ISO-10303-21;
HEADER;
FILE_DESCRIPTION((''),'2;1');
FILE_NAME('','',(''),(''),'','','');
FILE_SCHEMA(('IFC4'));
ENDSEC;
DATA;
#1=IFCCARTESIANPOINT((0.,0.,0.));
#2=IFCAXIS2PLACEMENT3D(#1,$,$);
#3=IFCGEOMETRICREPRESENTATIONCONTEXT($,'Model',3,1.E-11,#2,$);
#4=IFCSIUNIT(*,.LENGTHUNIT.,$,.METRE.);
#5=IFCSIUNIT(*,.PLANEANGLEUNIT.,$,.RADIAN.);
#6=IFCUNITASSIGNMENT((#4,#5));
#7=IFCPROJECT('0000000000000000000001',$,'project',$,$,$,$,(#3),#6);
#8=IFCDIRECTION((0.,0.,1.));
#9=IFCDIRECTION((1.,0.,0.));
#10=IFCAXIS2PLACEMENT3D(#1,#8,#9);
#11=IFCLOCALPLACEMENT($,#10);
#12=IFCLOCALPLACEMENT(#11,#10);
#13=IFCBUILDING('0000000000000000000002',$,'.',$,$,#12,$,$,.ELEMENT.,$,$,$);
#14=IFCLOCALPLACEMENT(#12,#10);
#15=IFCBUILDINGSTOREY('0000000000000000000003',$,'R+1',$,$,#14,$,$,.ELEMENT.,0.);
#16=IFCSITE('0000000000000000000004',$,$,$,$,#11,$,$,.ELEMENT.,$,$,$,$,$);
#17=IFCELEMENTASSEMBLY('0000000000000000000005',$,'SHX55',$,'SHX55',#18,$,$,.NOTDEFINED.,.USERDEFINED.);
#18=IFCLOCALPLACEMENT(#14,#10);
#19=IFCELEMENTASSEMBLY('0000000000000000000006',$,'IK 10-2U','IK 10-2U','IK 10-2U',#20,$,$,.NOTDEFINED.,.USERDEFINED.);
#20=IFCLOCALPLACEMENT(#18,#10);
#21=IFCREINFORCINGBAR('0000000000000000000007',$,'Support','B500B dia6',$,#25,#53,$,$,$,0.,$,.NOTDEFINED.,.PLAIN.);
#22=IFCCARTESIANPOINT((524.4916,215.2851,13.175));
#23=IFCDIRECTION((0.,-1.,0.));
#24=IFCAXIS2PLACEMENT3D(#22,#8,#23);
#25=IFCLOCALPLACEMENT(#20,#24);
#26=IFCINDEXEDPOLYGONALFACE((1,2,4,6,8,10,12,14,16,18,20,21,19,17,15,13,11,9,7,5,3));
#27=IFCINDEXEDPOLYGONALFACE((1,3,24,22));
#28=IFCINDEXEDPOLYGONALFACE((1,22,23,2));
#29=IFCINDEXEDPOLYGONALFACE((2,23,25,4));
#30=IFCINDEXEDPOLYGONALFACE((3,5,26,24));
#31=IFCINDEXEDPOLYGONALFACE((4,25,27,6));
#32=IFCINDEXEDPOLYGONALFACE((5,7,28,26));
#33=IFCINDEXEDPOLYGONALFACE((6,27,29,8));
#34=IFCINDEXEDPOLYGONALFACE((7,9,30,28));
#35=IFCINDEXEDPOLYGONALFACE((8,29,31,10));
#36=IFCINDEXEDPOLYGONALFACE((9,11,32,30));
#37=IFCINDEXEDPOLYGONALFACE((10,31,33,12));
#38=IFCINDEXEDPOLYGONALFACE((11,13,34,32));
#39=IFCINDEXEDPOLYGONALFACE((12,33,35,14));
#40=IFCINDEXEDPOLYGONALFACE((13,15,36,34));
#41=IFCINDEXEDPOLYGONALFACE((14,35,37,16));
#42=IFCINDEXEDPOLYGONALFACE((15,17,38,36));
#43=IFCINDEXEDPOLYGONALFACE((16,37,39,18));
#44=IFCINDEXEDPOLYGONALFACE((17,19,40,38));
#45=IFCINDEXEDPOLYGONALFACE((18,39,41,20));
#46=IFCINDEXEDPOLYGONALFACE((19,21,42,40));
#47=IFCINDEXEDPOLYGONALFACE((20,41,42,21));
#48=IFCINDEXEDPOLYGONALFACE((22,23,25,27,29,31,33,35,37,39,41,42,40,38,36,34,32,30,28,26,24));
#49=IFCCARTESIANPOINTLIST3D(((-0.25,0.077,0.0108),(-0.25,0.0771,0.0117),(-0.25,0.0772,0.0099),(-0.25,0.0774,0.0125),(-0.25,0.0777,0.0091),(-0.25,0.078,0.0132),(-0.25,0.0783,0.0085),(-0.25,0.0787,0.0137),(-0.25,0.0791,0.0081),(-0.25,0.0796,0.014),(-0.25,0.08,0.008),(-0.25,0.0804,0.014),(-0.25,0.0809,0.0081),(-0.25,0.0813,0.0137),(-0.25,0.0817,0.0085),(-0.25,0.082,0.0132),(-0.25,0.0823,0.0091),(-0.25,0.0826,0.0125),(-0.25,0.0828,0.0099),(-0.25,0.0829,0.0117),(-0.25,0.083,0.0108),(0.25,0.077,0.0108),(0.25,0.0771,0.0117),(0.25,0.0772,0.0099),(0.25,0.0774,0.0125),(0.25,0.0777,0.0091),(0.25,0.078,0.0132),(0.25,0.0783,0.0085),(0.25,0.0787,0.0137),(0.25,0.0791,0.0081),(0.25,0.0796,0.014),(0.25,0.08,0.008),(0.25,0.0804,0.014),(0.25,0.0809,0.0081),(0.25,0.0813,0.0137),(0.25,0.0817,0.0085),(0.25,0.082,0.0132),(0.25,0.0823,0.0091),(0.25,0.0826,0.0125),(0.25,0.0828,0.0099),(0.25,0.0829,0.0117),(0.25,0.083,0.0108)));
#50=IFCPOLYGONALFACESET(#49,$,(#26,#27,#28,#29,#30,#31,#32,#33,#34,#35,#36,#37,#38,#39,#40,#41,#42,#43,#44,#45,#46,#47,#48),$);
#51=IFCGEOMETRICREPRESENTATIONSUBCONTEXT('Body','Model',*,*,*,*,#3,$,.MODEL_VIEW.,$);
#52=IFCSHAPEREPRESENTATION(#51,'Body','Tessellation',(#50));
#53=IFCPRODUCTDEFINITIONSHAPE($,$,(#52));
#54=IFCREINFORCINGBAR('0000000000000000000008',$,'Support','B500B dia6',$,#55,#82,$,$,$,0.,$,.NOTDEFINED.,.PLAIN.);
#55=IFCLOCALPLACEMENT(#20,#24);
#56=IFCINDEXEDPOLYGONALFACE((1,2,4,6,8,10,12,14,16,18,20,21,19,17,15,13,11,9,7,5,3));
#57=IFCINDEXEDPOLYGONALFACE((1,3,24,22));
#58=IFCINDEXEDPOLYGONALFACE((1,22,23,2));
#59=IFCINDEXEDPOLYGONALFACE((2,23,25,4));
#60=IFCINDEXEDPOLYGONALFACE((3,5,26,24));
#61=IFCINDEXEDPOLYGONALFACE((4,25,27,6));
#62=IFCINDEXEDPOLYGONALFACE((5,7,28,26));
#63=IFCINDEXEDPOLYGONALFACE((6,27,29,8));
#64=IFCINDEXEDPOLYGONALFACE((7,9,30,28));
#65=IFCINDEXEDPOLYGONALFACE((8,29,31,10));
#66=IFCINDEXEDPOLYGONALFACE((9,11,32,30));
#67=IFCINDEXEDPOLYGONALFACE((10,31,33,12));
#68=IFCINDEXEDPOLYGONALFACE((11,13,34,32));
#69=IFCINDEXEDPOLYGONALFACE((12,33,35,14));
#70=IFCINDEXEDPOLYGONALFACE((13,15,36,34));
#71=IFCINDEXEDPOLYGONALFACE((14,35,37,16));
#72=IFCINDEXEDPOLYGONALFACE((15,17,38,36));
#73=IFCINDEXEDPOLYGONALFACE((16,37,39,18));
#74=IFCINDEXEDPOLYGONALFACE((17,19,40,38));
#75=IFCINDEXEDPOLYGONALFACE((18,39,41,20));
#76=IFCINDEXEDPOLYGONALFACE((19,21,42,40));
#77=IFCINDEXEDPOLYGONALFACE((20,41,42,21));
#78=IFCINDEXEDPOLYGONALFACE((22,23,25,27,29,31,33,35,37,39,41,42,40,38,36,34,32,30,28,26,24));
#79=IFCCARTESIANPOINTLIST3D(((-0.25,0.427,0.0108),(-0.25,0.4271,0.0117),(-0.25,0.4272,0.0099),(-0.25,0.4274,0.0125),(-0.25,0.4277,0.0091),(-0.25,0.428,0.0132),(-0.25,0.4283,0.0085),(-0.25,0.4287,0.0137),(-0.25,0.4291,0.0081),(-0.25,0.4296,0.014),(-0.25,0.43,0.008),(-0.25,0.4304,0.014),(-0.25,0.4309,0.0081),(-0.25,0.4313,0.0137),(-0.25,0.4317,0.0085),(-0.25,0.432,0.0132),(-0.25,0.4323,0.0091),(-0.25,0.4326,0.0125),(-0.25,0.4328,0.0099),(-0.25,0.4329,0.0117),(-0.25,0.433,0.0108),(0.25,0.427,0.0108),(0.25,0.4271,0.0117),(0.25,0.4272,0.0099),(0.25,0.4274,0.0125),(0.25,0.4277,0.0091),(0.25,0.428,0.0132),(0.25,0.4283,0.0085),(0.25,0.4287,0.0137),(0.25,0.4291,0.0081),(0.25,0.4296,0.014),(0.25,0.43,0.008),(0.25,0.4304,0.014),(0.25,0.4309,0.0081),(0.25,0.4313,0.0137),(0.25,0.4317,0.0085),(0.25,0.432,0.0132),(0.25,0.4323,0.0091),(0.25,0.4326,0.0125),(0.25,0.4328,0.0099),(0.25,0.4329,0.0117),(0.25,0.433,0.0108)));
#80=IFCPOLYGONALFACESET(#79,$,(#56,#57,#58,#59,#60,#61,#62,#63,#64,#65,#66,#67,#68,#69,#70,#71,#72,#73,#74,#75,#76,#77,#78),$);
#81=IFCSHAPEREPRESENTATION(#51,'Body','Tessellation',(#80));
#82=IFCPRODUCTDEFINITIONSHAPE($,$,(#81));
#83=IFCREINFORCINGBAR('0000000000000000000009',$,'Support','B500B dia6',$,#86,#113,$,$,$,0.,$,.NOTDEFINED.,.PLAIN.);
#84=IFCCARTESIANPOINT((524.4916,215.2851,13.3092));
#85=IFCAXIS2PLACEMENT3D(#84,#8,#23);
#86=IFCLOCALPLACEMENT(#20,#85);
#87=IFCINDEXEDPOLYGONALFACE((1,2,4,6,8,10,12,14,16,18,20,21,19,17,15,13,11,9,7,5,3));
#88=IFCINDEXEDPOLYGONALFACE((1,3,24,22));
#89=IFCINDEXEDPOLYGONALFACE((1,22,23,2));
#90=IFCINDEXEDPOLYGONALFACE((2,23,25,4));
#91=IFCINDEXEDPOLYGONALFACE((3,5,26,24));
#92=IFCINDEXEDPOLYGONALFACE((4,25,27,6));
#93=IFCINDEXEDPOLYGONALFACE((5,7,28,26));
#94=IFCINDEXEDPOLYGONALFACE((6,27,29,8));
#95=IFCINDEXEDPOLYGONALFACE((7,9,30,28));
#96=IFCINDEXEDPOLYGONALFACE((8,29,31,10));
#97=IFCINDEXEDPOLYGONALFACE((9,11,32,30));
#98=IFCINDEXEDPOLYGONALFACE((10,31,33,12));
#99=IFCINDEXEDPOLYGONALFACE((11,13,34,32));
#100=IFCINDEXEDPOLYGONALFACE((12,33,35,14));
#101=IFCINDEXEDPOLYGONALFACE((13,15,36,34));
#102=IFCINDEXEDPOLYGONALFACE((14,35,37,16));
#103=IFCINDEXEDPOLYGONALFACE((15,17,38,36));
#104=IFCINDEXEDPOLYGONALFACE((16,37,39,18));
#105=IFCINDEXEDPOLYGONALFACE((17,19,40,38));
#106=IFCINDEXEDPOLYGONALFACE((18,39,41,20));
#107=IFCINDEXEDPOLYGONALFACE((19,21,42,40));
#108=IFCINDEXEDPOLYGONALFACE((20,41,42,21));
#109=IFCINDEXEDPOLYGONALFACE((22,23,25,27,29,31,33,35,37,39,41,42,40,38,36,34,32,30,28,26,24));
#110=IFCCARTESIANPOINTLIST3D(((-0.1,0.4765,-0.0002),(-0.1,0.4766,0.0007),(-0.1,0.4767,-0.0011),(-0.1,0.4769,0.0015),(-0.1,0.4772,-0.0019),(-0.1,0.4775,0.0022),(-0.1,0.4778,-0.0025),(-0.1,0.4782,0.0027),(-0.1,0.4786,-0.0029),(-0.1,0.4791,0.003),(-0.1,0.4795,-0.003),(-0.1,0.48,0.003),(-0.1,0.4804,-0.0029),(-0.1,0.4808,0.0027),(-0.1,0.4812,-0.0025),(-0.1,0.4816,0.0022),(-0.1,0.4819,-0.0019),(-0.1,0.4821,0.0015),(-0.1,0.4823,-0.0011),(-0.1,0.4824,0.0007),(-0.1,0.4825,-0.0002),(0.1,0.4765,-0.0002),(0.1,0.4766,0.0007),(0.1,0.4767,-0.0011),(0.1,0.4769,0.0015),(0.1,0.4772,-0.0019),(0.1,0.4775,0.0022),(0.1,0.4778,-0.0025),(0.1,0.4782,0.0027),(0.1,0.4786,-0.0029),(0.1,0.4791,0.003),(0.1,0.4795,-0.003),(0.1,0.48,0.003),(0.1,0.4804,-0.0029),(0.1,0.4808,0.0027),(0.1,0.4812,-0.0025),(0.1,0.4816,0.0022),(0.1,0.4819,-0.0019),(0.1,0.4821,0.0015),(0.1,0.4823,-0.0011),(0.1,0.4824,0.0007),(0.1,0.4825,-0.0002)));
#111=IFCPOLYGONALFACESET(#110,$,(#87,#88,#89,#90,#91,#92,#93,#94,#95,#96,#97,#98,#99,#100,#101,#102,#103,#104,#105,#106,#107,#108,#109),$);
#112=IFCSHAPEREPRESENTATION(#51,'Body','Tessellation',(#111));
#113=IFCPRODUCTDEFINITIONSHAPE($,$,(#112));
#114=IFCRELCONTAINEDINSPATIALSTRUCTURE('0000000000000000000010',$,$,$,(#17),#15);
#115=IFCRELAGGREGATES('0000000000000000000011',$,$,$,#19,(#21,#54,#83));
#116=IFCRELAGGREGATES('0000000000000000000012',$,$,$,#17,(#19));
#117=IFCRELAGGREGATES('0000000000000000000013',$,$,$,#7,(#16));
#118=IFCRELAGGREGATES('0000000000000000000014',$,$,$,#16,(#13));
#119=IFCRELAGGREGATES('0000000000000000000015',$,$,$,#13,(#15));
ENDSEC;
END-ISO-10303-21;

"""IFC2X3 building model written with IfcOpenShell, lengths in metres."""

from ifc_helpers import new_model, entity, si_unit, frame, origin, origin_with_axes, place, context, subcontext, project, spatial, source, transform, mapped, element, aggregate, save


model = new_model("IFC2X3")

# Units and contexts
model_context = context("Model", 3, precision=1e-11, world=origin())
body_context = subcontext(model_context, "Body", "Model", "MODEL_VIEW")
ifc_project = project(units=[si_unit("LENGTHUNIT", "METRE"), si_unit("PLANEANGLEUNIT", "RADIAN")], contexts=[model_context])

# Site, building, storey
site_placement = place(None, origin_with_axes())
site = spatial("IfcSite", under=ifc_project, at=site_placement, CompositionType="ELEMENT")
building_placement = place(site_placement, origin_with_axes())
building = spatial("IfcBuilding", under=site, at=building_placement, Name=".", CompositionType="ELEMENT")
storey_placement = place(building_placement, origin_with_axes())
storey = spatial("IfcBuildingStorey", under=building, at=storey_placement, Name="R+1", CompositionType="ELEMENT", Elevation=0.0)

# Element assemblies, reinforcing bars
assembly_1_placement = place(storey_placement, origin_with_axes())
assembly_1 = element("IfcElementAssembly", 1, at=assembly_1_placement, inside=storey, Name="SHX55", ObjectType="SHX55", AssemblyPlace="NOTDEFINED", PredefinedType="USERDEFINED")
assembly_2_placement = place(assembly_1_placement, origin_with_axes())
assembly_2 = element("IfcElementAssembly", 2, at=assembly_2_placement, Name="IK 10-2U", Description="IK 10-2U", ObjectType="IK 10-2U", AssemblyPlace="NOTDEFINED", PredefinedType="USERDEFINED")
shared_shape_1 = source(origin_with_axes(), body_context, "Body", "AdvancedSweptSolid", [
    entity("IfcSweptDiskSolid", entity("IfcPolyline", [entity("IfcCartesianPoint", [0.25, 0.08, 0.011]), entity("IfcCartesianPoint", [-0.25, 0.08, 0.011])]), 0.003, None, 0.0, 0.5),
])
reinforcing_bar_1_placement = place(assembly_2_placement, frame((524.4916, 215.2851, 13.175), z_axis=(0.0, 0.0, 1.0), x_axis=(0.0, -1.0, 0.0)))
reinforcing_bar_1 = element("IfcReinforcingBar", 3, at=reinforcing_bar_1_placement, Name="Support", Description="B500B dia6", BarRole="NOTDEFINED", BarSurface="PLAIN", CrossSectionArea=0.0, context=body_context, shape_type="MappedRepresentation", body=[
    mapped(shared_shape_1, transform((0.0, 0.0, 0.0), scale=1.0)),
])
shared_shape_2 = source(origin_with_axes(), body_context, "Body", "AdvancedSweptSolid", [
    entity("IfcSweptDiskSolid", entity("IfcPolyline", [entity("IfcCartesianPoint", [0.25, 0.43, 0.011]), entity("IfcCartesianPoint", [-0.25, 0.43, 0.011])]), 0.003, None, 0.0, 0.5),
])
reinforcing_bar_2_placement = place(assembly_2_placement, frame((524.4916, 215.2851, 13.175), z_axis=(0.0, 0.0, 1.0), x_axis=(0.0, -1.0, 0.0)))
reinforcing_bar_2 = element("IfcReinforcingBar", 4, at=reinforcing_bar_2_placement, Name="Support", Description="B500B dia6", BarRole="NOTDEFINED", BarSurface="PLAIN", CrossSectionArea=0.0, context=body_context, shape_type="MappedRepresentation", body=[
    mapped(shared_shape_2, transform((0.0, 0.0, 0.0), scale=1.0)),
])
shared_shape_3 = source(origin_with_axes(), body_context, "Body", "AdvancedSweptSolid", [
    entity("IfcSweptDiskSolid", entity("IfcPolyline", [entity("IfcCartesianPoint", [0.1, 0.4795, 0.0]), entity("IfcCartesianPoint", [-0.1, 0.4795, 0.0])]), 0.003, None, 0.0, 0.2),
])
reinforcing_bar_3_placement = place(assembly_2_placement, frame((524.4916, 215.2851, 13.3092), z_axis=(0.0, 0.0, 1.0), x_axis=(0.0, -1.0, 0.0)))
reinforcing_bar_3 = element("IfcReinforcingBar", 5, at=reinforcing_bar_3_placement, Name="Support", Description="B500B dia6", BarRole="NOTDEFINED", BarSurface="PLAIN", CrossSectionArea=0.0, context=body_context, shape_type="MappedRepresentation", body=[
    mapped(shared_shape_3, transform((0.0, 0.0, 0.0), scale=1.0)),
])
aggregate(assembly_2, [reinforcing_bar_1, reinforcing_bar_2, reinforcing_bar_3])

aggregate(assembly_1, [assembly_2])

save(model, "model.ifc")
